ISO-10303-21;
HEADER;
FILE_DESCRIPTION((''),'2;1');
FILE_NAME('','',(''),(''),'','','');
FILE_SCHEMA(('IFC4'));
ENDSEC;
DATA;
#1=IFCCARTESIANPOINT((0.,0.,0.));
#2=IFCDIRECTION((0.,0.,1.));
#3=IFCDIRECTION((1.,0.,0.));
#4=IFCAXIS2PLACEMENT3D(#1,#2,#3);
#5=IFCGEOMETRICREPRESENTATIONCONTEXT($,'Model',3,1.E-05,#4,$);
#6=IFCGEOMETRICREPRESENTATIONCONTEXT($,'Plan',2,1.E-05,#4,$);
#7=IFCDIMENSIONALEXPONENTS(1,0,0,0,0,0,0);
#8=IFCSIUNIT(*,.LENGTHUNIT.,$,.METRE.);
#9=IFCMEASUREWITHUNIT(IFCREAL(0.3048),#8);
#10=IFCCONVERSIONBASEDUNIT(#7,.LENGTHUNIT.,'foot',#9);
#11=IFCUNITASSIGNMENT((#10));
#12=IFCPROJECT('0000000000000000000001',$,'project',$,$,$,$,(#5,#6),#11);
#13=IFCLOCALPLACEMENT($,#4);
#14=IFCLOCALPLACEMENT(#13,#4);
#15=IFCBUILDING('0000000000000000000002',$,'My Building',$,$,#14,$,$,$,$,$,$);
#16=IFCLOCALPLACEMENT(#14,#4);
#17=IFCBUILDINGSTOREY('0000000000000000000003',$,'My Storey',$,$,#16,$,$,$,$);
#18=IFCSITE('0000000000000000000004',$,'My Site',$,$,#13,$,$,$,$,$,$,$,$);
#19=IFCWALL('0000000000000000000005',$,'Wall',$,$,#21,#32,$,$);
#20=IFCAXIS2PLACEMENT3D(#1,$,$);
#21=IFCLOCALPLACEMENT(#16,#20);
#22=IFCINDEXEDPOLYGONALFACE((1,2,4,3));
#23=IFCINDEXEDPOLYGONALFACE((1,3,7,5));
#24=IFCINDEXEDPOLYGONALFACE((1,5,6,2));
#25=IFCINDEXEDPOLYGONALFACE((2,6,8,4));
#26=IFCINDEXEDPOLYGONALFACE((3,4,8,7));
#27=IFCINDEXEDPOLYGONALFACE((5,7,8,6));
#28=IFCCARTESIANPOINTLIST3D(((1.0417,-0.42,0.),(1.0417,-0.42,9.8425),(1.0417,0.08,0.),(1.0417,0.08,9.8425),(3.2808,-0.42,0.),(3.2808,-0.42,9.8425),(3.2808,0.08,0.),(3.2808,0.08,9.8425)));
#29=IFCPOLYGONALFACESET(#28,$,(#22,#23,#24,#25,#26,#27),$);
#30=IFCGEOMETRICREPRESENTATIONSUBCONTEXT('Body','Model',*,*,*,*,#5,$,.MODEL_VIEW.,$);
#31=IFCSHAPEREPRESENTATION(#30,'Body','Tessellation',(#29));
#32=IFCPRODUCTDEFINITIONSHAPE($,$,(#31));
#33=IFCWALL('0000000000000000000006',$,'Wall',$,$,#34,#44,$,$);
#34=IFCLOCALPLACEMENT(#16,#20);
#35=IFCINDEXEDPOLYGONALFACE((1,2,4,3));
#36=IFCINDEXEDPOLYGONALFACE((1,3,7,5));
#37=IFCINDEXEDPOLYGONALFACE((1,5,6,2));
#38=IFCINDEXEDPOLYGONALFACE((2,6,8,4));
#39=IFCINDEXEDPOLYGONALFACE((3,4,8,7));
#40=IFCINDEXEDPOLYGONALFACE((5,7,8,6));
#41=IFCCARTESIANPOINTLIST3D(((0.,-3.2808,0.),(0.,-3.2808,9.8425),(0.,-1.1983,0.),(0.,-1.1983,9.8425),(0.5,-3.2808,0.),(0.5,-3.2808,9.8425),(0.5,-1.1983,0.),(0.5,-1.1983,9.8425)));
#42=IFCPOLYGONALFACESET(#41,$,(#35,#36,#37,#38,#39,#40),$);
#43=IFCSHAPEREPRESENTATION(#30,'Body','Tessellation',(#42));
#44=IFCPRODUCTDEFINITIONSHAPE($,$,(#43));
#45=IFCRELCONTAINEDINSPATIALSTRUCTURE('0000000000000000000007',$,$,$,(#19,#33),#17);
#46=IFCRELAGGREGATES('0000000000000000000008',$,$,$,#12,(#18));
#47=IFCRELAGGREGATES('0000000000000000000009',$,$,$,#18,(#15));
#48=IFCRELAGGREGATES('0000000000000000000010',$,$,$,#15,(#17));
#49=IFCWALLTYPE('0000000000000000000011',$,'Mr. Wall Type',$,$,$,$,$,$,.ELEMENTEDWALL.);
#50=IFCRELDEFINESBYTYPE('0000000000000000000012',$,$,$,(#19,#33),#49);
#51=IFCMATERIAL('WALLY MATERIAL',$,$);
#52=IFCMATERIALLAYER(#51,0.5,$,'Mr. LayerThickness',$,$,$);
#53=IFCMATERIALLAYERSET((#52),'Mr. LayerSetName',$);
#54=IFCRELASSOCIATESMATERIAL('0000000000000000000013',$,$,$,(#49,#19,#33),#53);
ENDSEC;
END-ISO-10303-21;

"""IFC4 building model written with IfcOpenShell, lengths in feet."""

from ifc_helpers import new_model, entity, si_unit, converted_unit, frame, origin_with_axes, place, context, subcontext, project, spatial, polyline, outline, extrude, material, layer, layer_set, layer_usage, type_object, element, save


model = new_model("IFC4")

# Units and contexts
model_context = context("Model", 3, precision=1e-05, world=origin_with_axes())
plan_context = context("Plan", 2, precision=1e-05, world=origin_with_axes())
body_context = subcontext(model_context, "Body", "Model", "MODEL_VIEW")
ifc_project = project(units=[converted_unit("LENGTHUNIT", "foot", entity("IfcReal", 0.3048), si_unit("LENGTHUNIT", "METRE"), dimensions=[1, 0, 0, 0, 0, 0, 0])], contexts=[model_context, plan_context])

# Site, building, storey
site_placement = place(None, origin_with_axes())
site = spatial("IfcSite", under=ifc_project, at=site_placement, Name="My Site")
building_placement = place(site_placement, origin_with_axes())
building = spatial("IfcBuilding", under=site, at=building_placement, Name="My Building")
storey_placement = place(building_placement, origin_with_axes())
storey = spatial("IfcBuildingStorey", under=building, at=storey_placement, Name="My Storey")

# Walls
ifc_material = material(Name="WALLY MATERIAL")
ifc_layer = layer(ifc_material, 0.5, Name="Mr. LayerThickness")
ifc_layer_set = layer_set([ifc_layer], Name="Mr. LayerSetName")
ifc_layer_usage_1 = layer_usage(ifc_layer_set, "AXIS2", "POSITIVE", 0.0)
wall_type = type_object("IfcWallType", Name="Mr. Wall Type", PredefinedType="ELEMENTEDWALL", material=ifc_layer_set)
wall_1_placement = place(storey_placement, frame((3.2808, 0.08, 0.0), z_axis=(0.0, 0.0, 1.0), x_axis=(-1.0, 0.0, 0.0)))
element("IfcWall", 1, at=wall_1_placement, inside=storey, type_object=wall_type, material=ifc_layer_usage_1, Name="Wall", context=body_context, shape_type="SweptSolid", body=[
    extrude(outline(polyline([(-0.25, -1.1196), (0.25, -1.1196), (0.25, 1.1196), (-0.25, 1.1196), (-0.25, -1.1196)])), frame((1.1196, 0.25, 0.0), z_axis=(0.0, 0.0, -1.0), x_axis=(0.0, 1.0, 0.0)), (0.0, 0.0, -1.0), 9.8425),
])
ifc_layer_usage_2 = layer_usage(ifc_layer_set, "AXIS2", "POSITIVE", 0.0)
wall_2_placement = place(storey_placement, frame((0.0, -1.1983, 0.0), z_axis=(0.0, 0.0, 1.0), x_axis=(0.0, -1.0, 0.0)))
element("IfcWall", 2, at=wall_2_placement, inside=storey, type_object=wall_type, material=ifc_layer_usage_2, Name="Wall", context=body_context, shape_type="SweptSolid", body=[
    extrude(outline(polyline([(-0.25, -1.0413), (0.25, -1.0413), (0.25, 1.0413), (-0.25, 1.0413), (-0.25, -1.0413)])), frame((1.0413, 0.25, 0.0), z_axis=(0.0, 0.0, -1.0), x_axis=(0.0, -1.0, 0.0)), (0.0, 0.0, -1.0), 9.8425),
])

save(model, "model.ifc")
